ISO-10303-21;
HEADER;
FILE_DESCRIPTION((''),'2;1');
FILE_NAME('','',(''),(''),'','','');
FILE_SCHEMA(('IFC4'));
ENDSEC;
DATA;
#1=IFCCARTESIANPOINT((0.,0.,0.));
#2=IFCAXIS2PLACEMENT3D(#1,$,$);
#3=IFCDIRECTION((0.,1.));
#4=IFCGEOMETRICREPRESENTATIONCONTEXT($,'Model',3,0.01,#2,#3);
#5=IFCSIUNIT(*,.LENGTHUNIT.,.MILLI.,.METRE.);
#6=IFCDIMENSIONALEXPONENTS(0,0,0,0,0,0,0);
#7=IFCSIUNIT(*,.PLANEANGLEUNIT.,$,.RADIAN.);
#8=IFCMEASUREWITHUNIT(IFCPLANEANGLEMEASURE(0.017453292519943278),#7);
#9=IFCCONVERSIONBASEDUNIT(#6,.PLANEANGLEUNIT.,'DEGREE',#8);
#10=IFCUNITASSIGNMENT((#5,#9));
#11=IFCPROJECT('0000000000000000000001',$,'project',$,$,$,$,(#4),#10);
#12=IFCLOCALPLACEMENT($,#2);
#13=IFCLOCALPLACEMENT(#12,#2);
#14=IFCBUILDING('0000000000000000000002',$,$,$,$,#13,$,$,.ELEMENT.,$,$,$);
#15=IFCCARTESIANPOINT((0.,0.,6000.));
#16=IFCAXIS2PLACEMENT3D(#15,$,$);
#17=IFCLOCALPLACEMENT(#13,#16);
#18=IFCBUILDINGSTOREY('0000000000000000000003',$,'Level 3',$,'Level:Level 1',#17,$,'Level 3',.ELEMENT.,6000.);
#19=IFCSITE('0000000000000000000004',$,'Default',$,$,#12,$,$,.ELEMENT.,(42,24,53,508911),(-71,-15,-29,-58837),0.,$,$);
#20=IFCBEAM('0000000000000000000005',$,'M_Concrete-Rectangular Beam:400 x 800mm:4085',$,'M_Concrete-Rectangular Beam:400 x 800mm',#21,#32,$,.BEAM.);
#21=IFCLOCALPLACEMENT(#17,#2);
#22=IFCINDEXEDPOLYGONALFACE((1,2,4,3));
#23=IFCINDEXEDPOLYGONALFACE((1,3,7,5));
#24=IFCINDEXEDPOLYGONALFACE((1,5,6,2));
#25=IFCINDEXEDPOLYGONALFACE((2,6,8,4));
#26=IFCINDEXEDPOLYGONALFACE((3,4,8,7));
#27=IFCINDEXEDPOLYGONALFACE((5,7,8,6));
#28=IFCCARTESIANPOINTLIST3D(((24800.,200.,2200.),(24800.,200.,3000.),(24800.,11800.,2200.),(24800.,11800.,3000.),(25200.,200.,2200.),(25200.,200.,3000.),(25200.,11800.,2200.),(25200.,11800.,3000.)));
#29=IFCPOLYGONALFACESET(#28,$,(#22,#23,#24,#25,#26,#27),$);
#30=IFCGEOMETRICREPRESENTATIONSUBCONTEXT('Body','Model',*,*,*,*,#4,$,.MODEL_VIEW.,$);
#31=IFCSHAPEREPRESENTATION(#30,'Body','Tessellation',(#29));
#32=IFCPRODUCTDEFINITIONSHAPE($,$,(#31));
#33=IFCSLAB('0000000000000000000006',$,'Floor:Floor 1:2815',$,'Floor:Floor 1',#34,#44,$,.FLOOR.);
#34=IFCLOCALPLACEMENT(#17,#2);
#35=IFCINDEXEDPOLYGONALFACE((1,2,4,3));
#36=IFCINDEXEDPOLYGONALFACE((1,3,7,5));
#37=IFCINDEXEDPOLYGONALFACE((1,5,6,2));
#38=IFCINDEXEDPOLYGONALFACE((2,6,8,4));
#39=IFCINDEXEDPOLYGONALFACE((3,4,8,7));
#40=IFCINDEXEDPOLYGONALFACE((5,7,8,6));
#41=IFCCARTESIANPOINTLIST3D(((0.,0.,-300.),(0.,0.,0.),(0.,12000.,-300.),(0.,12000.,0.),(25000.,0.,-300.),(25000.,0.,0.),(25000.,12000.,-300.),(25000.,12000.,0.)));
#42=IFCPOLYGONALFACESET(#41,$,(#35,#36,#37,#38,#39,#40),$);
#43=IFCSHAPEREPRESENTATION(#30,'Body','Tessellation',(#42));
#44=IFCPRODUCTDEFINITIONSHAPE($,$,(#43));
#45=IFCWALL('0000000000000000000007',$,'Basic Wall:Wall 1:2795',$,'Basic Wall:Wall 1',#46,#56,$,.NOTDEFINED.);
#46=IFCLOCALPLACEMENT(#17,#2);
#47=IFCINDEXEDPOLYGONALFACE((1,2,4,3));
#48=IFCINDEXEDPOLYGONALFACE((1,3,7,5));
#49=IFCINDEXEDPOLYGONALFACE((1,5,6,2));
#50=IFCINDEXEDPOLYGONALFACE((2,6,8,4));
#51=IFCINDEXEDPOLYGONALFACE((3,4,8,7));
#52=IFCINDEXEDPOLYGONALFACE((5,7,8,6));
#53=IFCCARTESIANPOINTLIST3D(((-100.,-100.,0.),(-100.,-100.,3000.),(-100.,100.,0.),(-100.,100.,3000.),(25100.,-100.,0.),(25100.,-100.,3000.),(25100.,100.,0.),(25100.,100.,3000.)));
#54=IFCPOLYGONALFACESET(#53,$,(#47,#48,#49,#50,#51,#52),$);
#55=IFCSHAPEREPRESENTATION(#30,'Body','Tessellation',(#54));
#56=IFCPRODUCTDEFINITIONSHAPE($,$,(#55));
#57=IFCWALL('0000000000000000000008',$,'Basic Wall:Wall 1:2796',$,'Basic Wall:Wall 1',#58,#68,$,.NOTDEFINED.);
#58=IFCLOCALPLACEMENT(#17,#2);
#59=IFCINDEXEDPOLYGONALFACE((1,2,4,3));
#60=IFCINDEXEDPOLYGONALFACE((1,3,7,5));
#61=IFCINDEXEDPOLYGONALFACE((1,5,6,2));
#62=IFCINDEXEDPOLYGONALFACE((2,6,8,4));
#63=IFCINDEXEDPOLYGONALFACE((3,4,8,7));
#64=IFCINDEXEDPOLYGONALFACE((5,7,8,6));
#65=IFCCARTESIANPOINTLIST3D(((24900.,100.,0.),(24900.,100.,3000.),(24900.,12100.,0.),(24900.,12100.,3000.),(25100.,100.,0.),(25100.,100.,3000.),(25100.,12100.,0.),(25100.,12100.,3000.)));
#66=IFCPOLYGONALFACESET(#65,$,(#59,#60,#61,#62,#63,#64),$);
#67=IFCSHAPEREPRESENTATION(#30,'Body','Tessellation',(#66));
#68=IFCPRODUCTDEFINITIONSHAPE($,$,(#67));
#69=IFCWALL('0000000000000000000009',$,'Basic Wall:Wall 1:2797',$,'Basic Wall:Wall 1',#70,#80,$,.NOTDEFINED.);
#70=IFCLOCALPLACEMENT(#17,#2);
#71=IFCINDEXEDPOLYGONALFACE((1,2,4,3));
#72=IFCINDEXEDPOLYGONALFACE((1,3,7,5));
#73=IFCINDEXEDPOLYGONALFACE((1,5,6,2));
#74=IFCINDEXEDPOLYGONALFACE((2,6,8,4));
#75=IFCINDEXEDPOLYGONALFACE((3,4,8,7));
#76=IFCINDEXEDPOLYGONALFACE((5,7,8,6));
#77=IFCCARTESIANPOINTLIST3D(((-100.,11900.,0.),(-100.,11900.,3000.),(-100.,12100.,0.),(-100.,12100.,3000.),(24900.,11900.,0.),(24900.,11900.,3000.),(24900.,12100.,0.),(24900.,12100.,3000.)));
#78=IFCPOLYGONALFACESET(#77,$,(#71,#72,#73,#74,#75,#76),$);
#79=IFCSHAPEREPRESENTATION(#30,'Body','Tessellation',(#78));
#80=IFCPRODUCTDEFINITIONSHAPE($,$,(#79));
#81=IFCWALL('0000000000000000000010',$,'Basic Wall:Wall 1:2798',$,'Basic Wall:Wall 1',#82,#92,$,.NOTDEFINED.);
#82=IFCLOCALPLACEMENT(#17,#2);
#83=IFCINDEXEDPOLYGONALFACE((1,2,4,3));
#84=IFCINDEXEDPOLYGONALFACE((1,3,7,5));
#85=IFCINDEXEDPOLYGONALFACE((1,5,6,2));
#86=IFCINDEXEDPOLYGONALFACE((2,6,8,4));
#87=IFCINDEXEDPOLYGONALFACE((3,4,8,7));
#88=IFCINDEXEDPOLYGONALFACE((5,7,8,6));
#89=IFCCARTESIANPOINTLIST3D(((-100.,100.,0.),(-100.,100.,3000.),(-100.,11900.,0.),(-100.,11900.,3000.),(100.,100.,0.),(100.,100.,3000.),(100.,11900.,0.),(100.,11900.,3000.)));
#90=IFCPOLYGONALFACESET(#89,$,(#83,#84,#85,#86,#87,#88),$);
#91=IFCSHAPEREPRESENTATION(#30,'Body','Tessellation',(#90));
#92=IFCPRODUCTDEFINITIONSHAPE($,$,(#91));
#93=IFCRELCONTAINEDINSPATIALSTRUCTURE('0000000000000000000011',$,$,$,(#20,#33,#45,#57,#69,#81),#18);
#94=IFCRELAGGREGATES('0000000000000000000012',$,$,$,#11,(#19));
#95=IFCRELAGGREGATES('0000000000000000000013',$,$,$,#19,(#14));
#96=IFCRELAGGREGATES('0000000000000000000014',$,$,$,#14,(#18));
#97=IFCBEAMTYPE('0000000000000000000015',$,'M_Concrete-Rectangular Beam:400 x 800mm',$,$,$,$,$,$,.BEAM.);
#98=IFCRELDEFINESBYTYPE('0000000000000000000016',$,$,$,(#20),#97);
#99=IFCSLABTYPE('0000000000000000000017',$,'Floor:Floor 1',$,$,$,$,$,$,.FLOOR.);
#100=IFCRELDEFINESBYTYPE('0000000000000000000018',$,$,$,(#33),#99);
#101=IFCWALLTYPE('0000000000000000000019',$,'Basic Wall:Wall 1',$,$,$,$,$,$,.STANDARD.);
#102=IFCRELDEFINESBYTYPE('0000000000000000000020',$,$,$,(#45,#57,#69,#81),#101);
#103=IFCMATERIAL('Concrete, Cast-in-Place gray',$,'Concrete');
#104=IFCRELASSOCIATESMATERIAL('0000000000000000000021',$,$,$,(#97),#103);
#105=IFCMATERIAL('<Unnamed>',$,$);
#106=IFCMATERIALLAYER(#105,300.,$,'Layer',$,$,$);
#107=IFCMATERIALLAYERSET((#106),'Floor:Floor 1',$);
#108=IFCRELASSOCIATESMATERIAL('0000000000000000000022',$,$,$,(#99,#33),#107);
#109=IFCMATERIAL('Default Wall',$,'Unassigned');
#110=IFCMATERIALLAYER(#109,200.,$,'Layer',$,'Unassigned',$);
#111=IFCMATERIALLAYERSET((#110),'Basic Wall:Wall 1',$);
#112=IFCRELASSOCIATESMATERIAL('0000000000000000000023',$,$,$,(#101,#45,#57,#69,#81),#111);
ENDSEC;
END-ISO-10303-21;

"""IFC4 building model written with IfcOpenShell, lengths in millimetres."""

from ifc_helpers import new_model, entity, si_unit, converted_unit, direction, frame, frame_2d, origin, origin_2d_with_axis, place, context, subcontext, project, spatial, rectangle, extrude, source, transform, mapped, material, layer, layer_set, layer_usage, material_profile, profile_set, type_object, type_shapes, element, save


model = new_model("IFC4")

# Units and contexts
model_context = context("Model", 3, precision=0.01, world=origin(), true_north=direction((0.0, 1.0)))
body_context = subcontext(model_context, "Body", "Model", "MODEL_VIEW")
ifc_project = project(units=[si_unit("LENGTHUNIT", "METRE", prefix="MILLI"), converted_unit("PLANEANGLEUNIT", "DEGREE", entity("IfcPlaneAngleMeasure", 0.017453292519943278), si_unit("PLANEANGLEUNIT", "RADIAN"), dimensions=[0, 0, 0, 0, 0, 0, 0])], contexts=[model_context])

# Site, building, storey
site_placement = place(None, origin())
site = spatial("IfcSite", under=ifc_project, at=site_placement, Name="Default", CompositionType="ELEMENT", RefLatitude=(42, 24, 53, 508911), RefLongitude=(-71, -15, -29, -58837), RefElevation=0.0)
building_placement = place(site_placement, origin())
building = spatial("IfcBuilding", under=site, at=building_placement, CompositionType="ELEMENT")
storey_placement = place(building_placement, frame((0.0, 0.0, 6000.0)))
storey = spatial("IfcBuildingStorey", under=building, at=storey_placement, Name="Level 3", ObjectType="Level:Level 1", LongName="Level 3", CompositionType="ELEMENT", Elevation=6000.0)

# Beam
ifc_material_1 = material(Name="Concrete, Cast-in-Place gray", Category="Concrete")
ifc_material_profile = material_profile(ifc_material_1, rectangle(XDim=800.0, YDim=400.0, at=origin_2d_with_axis()), Name="400 x 800mm")
ifc_profile_set = profile_set([ifc_material_profile], Name="400 x 800mm")
beam_type_1 = type_object("IfcBeamType", Name="M_Concrete-Rectangular Beam:400 x 800mm", PredefinedType="BEAM", material=ifc_profile_set)
shared_shape_1 = source(origin(), body_context, "Body", "SweptSolid", [
    extrude(rectangle(XDim=800.0, YDim=400.0, at=frame_2d((0.0, 0.0), x_axis=(0.0, 1.0))), frame((25000.0, 200.0, 8600.0), z_axis=(0.0, 1.0, 0.0), x_axis=(-1.0, 0.0, 0.0)), (0.0, 0.0, 1.0), 11600.0),
])
type_shapes(beam_type_1, [shared_shape_1])
beam_1_placement = place(storey_placement, frame((0.0, 0.0, -6000.0)))
element("IfcBeam", 1, at=beam_1_placement, inside=storey, type_object=beam_type_1, Name="M_Concrete-Rectangular Beam:400 x 800mm:4085", ObjectType="M_Concrete-Rectangular Beam:400 x 800mm", PredefinedType="BEAM", context=body_context, shape_type="MappedRepresentation", body=[
    mapped(shared_shape_1, transform((0.0, 0.0, 0.0), scale=1.0)),
])

# Slab
ifc_material_2 = material(Name="<Unnamed>")
ifc_layer_1 = layer(ifc_material_2, 300.0, Name="Layer")
ifc_layer_set_1 = layer_set([ifc_layer_1], Name="Floor:Floor 1")
ifc_layer_usage_1 = layer_usage(ifc_layer_set_1, "AXIS3", "POSITIVE", 0.0)
slab_type = type_object("IfcSlabType", Name="Floor:Floor 1", PredefinedType="FLOOR", material=ifc_layer_set_1)
slab_placement = place(storey_placement, origin())
element("IfcSlab", 2, at=slab_placement, inside=storey, type_object=slab_type, material=ifc_layer_usage_1, Name="Floor:Floor 1:2815", ObjectType="Floor:Floor 1", PredefinedType="FLOOR", context=body_context, shape_type="SweptSolid", body=[
    extrude(rectangle(XDim=12000.0, YDim=25000.0, at=origin_2d_with_axis()), frame((12500.0, 6000.0, 0.0), z_axis=(0.0, 0.0, -1.0), x_axis=(0.0, 1.0, 0.0)), (0.0, 0.0, 1.0), 300.0),
])

# Walls
ifc_material_3 = material(Name="Default Wall", Category="Unassigned")
ifc_layer_2 = layer(ifc_material_3, 200.0, Name="Layer", Category="Unassigned")
ifc_layer_set_2 = layer_set([ifc_layer_2], Name="Basic Wall:Wall 1")
ifc_layer_usage_2 = layer_usage(ifc_layer_set_2, "AXIS2", "NEGATIVE", 100.0)
wall_type = type_object("IfcWallType", Name="Basic Wall:Wall 1", PredefinedType="STANDARD", material=ifc_layer_set_2)
wall_1_placement = place(storey_placement, frame((-100.0, 0.0, 0.0)))
element("IfcWall", 3, at=wall_1_placement, inside=storey, type_object=wall_type, material=ifc_layer_usage_2, Name="Basic Wall:Wall 1:2795", ObjectType="Basic Wall:Wall 1", PredefinedType="NOTDEFINED", context=body_context, shape_type="SweptSolid", body=[
    extrude(rectangle(XDim=25200.0, YDim=200.0, at=frame_2d((12600.0, 0.0), x_axis=(-1.0, 0.0))), origin(), (0.0, 0.0, 1.0), 3000.0),
])
ifc_layer_usage_3 = layer_usage(ifc_layer_set_2, "AXIS2", "NEGATIVE", 100.0)
wall_2_placement = place(storey_placement, frame((25000.0, 100.0, 0.0), z_axis=(0.0, 0.0, 1.0), x_axis=(0.0, 1.0, 0.0)))
element("IfcWall", 4, at=wall_2_placement, inside=storey, type_object=wall_type, material=ifc_layer_usage_3, Name="Basic Wall:Wall 1:2796", ObjectType="Basic Wall:Wall 1", PredefinedType="NOTDEFINED", context=body_context, shape_type="SweptSolid", body=[
    extrude(rectangle(XDim=12000.0, YDim=200.0, at=frame_2d((6000.0, 0.0), x_axis=(-1.0, 0.0))), origin(), (0.0, 0.0, 1.0), 3000.0),
])
ifc_layer_usage_4 = layer_usage(ifc_layer_set_2, "AXIS2", "NEGATIVE", 100.0)
wall_3_placement = place(storey_placement, frame((24900.0, 12000.0, 0.0), z_axis=(0.0, 0.0, 1.0), x_axis=(-1.0, 0.0, 0.0)))
element("IfcWall", 5, at=wall_3_placement, inside=storey, type_object=wall_type, material=ifc_layer_usage_4, Name="Basic Wall:Wall 1:2797", ObjectType="Basic Wall:Wall 1", PredefinedType="NOTDEFINED", context=body_context, shape_type="SweptSolid", body=[
    extrude(rectangle(XDim=25000.0, YDim=200.0, at=frame_2d((12500.0, 0.0), x_axis=(-1.0, 0.0))), origin(), (0.0, 0.0, 1.0), 3000.0),
])
ifc_layer_usage_5 = layer_usage(ifc_layer_set_2, "AXIS2", "NEGATIVE", 100.0)
wall_4_placement = place(storey_placement, frame((0.0, 11900.0, 0.0), z_axis=(0.0, 0.0, 1.0), x_axis=(0.0, -1.0, 0.0)))
element("IfcWall", 6, at=wall_4_placement, inside=storey, type_object=wall_type, material=ifc_layer_usage_5, Name="Basic Wall:Wall 1:2798", ObjectType="Basic Wall:Wall 1", PredefinedType="NOTDEFINED", context=body_context, shape_type="SweptSolid", body=[
    extrude(rectangle(XDim=11800.0, YDim=200.0, at=frame_2d((5900.0, 0.0), x_axis=(-1.0, 0.0))), origin(), (0.0, 0.0, 1.0), 3000.0),
])

save(model, "model.ifc")
